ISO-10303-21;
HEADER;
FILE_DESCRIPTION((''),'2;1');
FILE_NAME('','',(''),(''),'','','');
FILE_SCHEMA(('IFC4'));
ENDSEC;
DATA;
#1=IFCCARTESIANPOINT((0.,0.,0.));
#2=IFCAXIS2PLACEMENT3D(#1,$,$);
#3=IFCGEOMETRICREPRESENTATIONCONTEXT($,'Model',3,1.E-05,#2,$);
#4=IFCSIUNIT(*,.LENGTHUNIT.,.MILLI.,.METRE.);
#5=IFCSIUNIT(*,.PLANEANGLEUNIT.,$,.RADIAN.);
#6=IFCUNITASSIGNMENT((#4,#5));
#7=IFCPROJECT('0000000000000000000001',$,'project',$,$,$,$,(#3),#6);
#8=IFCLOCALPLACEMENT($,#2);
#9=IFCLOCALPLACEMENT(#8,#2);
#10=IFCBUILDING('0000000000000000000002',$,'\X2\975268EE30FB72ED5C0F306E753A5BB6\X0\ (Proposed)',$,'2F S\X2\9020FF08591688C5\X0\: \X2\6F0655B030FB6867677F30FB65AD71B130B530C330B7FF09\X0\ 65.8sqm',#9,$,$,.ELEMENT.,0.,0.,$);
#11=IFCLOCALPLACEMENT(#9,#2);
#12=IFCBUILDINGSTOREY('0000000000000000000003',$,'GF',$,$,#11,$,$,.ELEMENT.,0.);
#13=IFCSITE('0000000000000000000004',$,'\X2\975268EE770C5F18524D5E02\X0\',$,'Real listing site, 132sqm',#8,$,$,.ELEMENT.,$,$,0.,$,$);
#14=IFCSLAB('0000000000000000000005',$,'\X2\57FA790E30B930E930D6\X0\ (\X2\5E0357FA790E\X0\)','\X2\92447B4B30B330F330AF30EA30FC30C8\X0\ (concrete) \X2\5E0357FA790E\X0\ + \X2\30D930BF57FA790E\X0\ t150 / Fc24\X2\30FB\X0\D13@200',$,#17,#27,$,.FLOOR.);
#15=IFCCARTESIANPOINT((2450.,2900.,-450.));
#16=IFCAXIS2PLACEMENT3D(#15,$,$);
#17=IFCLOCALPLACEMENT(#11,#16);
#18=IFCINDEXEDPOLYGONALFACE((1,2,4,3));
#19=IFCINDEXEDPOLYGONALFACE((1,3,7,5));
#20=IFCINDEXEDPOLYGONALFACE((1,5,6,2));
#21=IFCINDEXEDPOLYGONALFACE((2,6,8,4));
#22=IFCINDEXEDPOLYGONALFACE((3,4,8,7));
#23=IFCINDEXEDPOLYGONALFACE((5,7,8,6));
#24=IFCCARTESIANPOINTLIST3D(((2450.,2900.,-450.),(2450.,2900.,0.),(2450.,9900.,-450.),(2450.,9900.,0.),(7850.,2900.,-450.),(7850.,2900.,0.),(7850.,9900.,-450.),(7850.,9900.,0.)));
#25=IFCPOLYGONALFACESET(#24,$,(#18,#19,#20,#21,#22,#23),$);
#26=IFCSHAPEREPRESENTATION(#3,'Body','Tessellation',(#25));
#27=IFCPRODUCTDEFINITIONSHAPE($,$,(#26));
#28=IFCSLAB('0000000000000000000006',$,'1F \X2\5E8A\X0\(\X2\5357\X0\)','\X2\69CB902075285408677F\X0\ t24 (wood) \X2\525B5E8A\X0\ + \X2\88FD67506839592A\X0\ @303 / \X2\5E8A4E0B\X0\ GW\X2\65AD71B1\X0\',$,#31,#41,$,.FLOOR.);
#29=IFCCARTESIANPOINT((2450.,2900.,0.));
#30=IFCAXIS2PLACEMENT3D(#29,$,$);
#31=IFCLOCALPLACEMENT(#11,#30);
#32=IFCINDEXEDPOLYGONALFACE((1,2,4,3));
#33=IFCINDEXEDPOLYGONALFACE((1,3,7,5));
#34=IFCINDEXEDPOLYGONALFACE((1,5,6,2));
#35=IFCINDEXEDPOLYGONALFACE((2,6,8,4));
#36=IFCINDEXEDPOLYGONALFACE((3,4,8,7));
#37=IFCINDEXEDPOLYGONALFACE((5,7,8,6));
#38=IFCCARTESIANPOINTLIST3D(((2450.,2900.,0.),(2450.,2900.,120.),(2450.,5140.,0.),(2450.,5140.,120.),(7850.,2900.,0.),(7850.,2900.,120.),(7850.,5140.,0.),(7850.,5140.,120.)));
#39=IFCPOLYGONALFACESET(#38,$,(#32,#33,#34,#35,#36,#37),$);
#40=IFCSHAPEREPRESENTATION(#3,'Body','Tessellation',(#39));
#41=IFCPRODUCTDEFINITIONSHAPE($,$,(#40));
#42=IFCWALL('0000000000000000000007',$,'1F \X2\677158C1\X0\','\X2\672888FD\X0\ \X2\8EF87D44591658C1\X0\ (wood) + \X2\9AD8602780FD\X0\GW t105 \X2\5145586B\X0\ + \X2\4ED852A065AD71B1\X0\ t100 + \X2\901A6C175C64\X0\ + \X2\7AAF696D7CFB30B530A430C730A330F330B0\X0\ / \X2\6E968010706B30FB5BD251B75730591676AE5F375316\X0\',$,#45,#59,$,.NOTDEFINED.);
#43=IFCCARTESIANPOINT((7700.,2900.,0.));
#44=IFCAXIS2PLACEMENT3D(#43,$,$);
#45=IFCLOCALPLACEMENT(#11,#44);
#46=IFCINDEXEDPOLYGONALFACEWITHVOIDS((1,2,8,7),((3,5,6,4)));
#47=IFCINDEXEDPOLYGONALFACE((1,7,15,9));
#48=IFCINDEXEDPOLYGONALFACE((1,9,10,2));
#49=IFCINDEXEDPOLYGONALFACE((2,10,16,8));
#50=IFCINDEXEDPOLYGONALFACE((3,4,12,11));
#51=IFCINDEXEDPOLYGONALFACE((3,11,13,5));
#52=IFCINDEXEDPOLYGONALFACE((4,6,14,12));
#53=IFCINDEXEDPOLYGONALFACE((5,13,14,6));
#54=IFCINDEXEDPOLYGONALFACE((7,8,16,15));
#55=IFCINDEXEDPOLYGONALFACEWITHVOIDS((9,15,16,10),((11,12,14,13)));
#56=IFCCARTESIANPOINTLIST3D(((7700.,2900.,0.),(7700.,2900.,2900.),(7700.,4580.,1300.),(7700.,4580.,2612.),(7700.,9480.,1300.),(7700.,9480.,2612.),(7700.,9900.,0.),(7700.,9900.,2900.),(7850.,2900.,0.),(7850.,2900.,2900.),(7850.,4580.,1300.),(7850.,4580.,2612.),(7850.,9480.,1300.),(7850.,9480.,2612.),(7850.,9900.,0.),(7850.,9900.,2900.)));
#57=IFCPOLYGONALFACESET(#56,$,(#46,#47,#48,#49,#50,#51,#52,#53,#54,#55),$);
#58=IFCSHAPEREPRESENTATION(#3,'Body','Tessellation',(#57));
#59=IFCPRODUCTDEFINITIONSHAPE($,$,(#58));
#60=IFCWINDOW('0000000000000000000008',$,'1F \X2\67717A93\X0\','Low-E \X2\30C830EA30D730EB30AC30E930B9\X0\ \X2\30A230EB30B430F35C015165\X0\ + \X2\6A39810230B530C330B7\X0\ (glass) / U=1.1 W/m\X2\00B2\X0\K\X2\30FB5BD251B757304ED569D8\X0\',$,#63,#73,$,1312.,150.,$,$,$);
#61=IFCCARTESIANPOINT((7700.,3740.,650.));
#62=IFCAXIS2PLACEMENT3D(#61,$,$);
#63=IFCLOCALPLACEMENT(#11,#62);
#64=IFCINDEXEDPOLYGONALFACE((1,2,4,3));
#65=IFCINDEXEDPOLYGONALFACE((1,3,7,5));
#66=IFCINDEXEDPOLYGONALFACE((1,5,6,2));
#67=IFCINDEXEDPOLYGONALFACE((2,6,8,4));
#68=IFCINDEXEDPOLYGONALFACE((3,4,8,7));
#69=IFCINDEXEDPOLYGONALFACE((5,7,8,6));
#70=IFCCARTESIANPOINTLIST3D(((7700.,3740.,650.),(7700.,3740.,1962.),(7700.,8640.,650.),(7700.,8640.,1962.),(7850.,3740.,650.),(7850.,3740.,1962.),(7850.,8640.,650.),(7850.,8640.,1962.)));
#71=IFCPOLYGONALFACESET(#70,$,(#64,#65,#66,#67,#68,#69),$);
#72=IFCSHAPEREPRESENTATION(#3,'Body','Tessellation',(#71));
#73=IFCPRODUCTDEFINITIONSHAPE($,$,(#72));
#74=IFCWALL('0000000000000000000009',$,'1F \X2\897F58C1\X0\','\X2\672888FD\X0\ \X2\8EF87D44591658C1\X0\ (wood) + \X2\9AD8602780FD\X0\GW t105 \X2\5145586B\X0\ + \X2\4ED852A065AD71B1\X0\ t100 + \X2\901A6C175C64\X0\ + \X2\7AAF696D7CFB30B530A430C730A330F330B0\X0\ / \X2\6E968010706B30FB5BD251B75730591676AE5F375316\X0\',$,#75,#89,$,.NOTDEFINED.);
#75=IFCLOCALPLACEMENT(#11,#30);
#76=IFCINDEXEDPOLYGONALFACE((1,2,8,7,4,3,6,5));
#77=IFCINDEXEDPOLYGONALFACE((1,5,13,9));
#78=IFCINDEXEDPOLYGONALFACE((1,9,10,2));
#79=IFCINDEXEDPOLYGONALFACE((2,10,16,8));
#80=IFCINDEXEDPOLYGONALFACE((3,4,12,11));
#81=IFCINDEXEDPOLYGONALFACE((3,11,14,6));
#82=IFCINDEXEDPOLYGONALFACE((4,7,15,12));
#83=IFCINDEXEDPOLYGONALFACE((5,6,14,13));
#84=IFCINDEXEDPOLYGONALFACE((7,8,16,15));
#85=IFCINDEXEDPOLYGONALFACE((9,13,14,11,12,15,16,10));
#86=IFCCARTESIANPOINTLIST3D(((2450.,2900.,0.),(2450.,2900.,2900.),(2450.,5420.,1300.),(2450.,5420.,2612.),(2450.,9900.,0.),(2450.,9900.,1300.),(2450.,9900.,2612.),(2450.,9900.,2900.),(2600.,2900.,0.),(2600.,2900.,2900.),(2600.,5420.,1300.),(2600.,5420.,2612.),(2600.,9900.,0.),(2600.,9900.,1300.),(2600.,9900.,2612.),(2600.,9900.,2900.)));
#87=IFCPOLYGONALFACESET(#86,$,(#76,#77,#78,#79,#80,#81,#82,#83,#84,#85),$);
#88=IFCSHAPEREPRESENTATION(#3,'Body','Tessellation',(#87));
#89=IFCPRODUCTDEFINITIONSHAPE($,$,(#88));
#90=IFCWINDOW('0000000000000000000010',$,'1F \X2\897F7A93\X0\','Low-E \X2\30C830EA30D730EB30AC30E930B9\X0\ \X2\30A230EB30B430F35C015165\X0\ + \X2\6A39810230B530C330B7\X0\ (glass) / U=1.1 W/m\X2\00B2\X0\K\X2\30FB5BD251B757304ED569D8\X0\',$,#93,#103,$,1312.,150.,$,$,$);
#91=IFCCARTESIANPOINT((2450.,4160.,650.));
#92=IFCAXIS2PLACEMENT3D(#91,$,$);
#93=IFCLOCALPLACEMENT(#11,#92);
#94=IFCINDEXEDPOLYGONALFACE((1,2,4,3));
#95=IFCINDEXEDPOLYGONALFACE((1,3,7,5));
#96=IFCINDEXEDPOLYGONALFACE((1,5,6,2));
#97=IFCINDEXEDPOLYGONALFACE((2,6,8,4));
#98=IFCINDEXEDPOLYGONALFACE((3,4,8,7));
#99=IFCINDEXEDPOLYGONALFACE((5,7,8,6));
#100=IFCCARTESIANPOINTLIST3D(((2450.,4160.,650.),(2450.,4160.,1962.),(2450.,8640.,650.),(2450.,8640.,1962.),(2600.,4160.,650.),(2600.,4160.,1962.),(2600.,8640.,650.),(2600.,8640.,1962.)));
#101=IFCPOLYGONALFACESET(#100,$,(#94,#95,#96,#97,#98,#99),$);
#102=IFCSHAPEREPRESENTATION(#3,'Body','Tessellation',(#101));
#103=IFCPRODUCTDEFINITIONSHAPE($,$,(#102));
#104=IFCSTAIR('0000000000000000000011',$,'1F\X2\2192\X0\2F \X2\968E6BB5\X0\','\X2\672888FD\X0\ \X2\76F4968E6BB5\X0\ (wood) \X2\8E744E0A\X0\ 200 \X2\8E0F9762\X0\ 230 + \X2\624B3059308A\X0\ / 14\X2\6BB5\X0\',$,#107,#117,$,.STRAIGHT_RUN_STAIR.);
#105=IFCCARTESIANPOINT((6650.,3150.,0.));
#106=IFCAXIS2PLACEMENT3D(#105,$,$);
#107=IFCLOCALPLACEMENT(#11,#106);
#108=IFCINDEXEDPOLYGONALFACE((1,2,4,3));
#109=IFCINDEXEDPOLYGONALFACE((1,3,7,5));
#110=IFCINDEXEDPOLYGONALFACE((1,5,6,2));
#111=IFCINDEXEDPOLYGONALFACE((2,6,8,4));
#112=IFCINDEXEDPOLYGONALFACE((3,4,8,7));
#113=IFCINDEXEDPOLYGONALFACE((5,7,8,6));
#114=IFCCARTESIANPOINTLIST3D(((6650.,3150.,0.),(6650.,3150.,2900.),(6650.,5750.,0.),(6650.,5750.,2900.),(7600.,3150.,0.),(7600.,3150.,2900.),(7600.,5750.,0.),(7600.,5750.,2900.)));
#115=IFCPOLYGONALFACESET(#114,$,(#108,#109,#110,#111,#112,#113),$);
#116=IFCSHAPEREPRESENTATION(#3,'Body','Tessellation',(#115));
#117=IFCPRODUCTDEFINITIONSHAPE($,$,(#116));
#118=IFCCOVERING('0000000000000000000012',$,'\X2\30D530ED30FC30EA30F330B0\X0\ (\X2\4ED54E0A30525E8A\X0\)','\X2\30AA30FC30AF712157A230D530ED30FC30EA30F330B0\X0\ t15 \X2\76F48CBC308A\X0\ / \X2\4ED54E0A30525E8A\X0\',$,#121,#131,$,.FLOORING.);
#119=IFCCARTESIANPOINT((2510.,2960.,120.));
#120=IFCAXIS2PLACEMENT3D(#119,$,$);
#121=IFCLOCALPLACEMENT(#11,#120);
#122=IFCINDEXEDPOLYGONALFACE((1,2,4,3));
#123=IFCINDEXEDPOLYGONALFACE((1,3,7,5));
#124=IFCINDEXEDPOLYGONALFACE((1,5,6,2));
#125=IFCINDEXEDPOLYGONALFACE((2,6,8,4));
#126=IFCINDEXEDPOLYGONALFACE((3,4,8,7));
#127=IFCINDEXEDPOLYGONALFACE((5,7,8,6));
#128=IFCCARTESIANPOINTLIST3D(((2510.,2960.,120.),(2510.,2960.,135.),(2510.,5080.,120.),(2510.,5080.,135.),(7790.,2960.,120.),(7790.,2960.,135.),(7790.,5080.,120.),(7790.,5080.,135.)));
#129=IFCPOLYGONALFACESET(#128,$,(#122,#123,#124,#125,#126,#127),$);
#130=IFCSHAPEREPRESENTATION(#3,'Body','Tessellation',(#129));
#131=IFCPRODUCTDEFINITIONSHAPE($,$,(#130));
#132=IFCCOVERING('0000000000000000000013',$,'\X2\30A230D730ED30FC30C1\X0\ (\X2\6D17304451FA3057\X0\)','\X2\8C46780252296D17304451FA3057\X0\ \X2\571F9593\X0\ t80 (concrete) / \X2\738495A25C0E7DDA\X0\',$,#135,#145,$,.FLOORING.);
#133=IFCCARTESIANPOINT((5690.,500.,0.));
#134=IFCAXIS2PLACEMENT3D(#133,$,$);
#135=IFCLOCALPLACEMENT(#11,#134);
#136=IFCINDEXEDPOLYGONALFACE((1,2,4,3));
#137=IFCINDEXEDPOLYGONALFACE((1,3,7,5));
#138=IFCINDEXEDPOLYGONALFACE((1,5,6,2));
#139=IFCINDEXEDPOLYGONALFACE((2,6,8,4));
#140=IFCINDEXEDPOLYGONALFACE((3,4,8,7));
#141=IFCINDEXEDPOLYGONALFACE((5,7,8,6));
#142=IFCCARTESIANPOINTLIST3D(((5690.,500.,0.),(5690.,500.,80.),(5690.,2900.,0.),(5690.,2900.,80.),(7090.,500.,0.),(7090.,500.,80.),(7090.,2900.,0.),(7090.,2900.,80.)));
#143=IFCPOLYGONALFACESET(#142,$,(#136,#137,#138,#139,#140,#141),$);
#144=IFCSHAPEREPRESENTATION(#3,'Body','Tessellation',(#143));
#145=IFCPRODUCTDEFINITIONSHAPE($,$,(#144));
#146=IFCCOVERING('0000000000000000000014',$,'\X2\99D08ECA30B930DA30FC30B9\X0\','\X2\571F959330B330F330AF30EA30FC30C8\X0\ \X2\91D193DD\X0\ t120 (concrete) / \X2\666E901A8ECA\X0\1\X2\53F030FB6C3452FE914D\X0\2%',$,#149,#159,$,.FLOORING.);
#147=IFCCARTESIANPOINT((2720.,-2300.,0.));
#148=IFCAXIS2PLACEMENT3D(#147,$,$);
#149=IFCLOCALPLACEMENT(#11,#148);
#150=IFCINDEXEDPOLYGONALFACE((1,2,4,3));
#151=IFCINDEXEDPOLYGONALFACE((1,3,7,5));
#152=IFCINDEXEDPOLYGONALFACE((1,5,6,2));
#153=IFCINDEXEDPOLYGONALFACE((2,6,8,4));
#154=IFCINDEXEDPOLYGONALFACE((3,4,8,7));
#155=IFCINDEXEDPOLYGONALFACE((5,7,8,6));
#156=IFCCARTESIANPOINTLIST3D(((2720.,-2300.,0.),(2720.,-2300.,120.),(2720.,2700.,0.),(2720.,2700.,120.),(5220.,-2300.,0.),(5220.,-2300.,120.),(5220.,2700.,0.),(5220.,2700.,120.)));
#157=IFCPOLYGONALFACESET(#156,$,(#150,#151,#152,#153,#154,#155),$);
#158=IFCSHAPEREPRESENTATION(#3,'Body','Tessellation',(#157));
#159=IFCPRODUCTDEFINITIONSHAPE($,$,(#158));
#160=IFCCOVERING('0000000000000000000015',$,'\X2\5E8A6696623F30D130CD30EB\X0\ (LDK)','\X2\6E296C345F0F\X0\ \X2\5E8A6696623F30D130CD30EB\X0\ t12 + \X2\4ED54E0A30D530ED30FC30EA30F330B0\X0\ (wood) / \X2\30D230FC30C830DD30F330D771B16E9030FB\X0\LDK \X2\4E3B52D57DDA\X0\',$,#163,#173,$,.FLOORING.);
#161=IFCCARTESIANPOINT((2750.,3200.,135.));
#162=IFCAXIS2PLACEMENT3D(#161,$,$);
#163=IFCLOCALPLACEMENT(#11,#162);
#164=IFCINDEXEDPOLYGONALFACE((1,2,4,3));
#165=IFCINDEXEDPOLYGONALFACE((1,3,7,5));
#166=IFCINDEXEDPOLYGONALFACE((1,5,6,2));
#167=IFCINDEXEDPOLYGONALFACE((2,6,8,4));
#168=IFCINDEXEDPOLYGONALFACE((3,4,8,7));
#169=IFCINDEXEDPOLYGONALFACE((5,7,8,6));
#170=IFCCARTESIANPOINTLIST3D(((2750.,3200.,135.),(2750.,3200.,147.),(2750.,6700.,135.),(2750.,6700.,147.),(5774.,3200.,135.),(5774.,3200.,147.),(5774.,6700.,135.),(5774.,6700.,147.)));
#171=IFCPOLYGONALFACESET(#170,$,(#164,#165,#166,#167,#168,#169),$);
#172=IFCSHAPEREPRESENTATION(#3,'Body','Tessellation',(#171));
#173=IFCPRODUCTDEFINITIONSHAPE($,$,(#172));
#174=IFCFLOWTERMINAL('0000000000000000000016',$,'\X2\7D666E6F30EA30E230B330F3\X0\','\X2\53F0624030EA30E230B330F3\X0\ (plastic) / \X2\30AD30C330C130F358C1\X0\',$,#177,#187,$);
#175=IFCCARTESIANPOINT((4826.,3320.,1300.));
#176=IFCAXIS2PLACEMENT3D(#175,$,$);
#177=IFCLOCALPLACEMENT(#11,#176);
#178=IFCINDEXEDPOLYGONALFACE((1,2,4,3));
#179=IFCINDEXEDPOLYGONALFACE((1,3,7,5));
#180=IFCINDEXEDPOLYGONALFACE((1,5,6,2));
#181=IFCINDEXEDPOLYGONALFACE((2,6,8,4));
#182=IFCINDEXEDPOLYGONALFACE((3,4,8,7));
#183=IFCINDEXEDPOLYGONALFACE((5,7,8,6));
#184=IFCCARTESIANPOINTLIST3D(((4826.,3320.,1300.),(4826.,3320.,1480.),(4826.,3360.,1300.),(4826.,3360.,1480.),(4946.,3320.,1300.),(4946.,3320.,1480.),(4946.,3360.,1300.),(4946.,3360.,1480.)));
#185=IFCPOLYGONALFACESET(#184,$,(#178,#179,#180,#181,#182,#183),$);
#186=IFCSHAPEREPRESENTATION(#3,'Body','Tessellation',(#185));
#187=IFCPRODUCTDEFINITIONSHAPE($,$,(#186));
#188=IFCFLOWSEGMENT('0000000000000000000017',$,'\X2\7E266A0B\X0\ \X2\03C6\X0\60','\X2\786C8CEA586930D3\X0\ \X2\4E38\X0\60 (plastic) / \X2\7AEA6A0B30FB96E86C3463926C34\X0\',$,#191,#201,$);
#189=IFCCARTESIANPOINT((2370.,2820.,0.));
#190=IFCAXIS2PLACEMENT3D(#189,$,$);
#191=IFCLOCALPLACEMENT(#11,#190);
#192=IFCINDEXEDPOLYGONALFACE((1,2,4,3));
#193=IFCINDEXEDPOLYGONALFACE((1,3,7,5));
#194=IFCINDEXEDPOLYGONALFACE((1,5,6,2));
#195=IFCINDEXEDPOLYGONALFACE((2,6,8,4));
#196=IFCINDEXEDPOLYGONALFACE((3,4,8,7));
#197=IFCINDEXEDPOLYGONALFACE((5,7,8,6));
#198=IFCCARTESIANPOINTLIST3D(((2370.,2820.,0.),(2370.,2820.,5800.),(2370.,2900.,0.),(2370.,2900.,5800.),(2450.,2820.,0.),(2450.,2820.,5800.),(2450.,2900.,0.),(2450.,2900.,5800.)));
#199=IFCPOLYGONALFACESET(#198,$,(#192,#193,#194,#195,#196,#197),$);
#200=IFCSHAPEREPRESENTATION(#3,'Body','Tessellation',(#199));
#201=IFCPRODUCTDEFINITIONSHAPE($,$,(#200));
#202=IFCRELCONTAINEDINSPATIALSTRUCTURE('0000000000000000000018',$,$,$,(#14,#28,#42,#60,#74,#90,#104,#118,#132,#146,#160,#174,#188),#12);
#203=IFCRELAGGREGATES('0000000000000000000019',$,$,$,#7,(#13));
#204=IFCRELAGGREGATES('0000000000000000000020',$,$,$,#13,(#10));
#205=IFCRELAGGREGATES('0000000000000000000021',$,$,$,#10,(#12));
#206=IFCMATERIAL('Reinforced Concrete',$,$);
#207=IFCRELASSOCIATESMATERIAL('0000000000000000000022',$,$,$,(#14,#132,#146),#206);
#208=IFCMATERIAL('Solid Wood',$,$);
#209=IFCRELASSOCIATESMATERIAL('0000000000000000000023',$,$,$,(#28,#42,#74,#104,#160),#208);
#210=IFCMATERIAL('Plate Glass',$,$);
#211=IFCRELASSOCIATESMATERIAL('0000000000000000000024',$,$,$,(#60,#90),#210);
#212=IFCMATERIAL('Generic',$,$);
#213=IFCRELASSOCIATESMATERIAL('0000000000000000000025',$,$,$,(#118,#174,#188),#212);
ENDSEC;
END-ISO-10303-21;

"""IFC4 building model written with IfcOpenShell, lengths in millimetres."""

from ifc_helpers import new_model, si_unit, frame, frame_2d, origin, place, context, project, spatial, rectangle, extrude, material, element, fill, save


model = new_model("IFC4")

# Units and contexts
model_context = context("Model", 3, precision=1e-05, world=origin())
ifc_project = project(units=[si_unit("LENGTHUNIT", "METRE", prefix="MILLI"), si_unit("PLANEANGLEUNIT", "RADIAN")], contexts=[model_context])

# Site, building, storey
site_placement = place(None, origin())
site = spatial("IfcSite", under=ifc_project, at=site_placement, Name="青森県弘前市", ObjectType="Real listing site, 132sqm", CompositionType="ELEMENT", RefElevation=0.0)
building_placement = place(site_placement, origin())
building = spatial("IfcBuilding", under=site, at=building_placement, Name="青森・狭小の町家 (Proposed)", ObjectType="2F S造（外装: 漆喰・桧板・断熱サッシ） 65.8sqm", CompositionType="ELEMENT", ElevationOfRefHeight=0.0, ElevationOfTerrain=0.0)
storey_placement = place(building_placement, origin())
storey = spatial("IfcBuildingStorey", under=building, at=storey_placement, Name="GF", CompositionType="ELEMENT", Elevation=0.0)

# Shared definitions
ifc_material_1 = material(Name="Solid Wood")

# Slabs
ifc_material_2 = material(Name="Reinforced Concrete")
slab_1_placement = place(storey_placement, frame((2450.0, 2900.0, -450.0)))
element("IfcSlab", 1, at=slab_1_placement, inside=storey, material=ifc_material_2, Name="基礎スラブ (布基礎)", Description="鉄筋コンクリート (concrete) 布基礎 + ベタ基礎 t150 / Fc24・D13@200", PredefinedType="FLOOR", context=model_context, shape_type="SweptSolid", body=[
    extrude(rectangle(XDim=5400.0, YDim=7000.0, at=frame_2d((2700.0, 3500.0))), frame((2450.0, 2900.0, -450.0)), (0.0, 0.0, 1.0), 450.0),
])
slab_2_placement = place(storey_placement, frame((2450.0, 2900.0, 0.0)))
element("IfcSlab", 2, at=slab_2_placement, inside=storey, material=ifc_material_1, Name="1F 床(南)", Description="構造用合板 t24 (wood) 剛床 + 製材根太 @303 / 床下 GW断熱", PredefinedType="FLOOR", context=model_context, shape_type="SweptSolid", body=[
    extrude(rectangle(XDim=5400.0, YDim=2240.0, at=frame_2d((2700.0, 1120.0))), frame((2450.0, 2900.0, 0.0)), (0.0, 0.0, 1.0), 120.0),
])

# Shared definitions
ifc_material_3 = material(Name="Plate Glass")

# Walls, openings, windows
wall_1_placement = place(storey_placement, frame((7700.0, 2900.0, 0.0)))
wall_1 = element("IfcWall", 3, at=wall_1_placement, inside=storey, material=ifc_material_1, Name="1F 東壁", Description="木製 軸組外壁 (wood) + 高性能GW t105 充填 + 付加断熱 t100 + 通気層 + 窯業系サイディング / 準耐火・寒冷地外皮強化", PredefinedType="NOTDEFINED", context=model_context, shape_type="SweptSolid", body=[
    extrude(rectangle(XDim=150.0, YDim=7000.0, at=frame_2d((75.0, 3500.0))), frame((7700.0, 2900.0, 0.0)), (0.0, 0.0, 1.0), 2900.0),
])
opening_1_placement = place(storey_placement, frame((7700.0, 3740.0, 650.0)))
opening_1 = element("IfcOpeningElement", 4, at=opening_1_placement, cuts=wall_1, PredefinedType="NOTDEFINED", context=model_context, shape_type="SweptSolid", body=[
    extrude(rectangle(XDim=150.0, YDim=4900.0, at=frame_2d((75.0, 2450.0))), frame((7700.0, 3740.0, 650.0)), (0.0, 0.0, 1.0), 1312.0),
])
window_1_placement = place(storey_placement, frame((7700.0, 3740.0, 650.0)))
window_1 = element("IfcWindow", 5, at=window_1_placement, inside=storey, material=ifc_material_3, Name="1F 東窓", Description="Low-E トリプルガラス アルゴン封入 + 樹脂サッシ (glass) / U=1.1 W/m²K・寒冷地仕様", OverallHeight=1312.0, OverallWidth=150.0, context=model_context, shape_type="SweptSolid", body=[
    extrude(rectangle(XDim=150.0, YDim=4900.0, at=frame_2d((75.0, 2450.0))), frame((7700.0, 3740.0, 650.0)), (0.0, 0.0, 1.0), 1312.0),
])
fill(opening_1, window_1)
wall_2_placement = place(storey_placement, frame((2450.0, 2900.0, 0.0)))
wall_2 = element("IfcWall", 6, at=wall_2_placement, inside=storey, material=ifc_material_1, Name="1F 西壁", Description="木製 軸組外壁 (wood) + 高性能GW t105 充填 + 付加断熱 t100 + 通気層 + 窯業系サイディング / 準耐火・寒冷地外皮強化", PredefinedType="NOTDEFINED", context=model_context, shape_type="SweptSolid", body=[
    extrude(rectangle(XDim=150.0, YDim=7000.0, at=frame_2d((75.0, 3500.0))), frame((2450.0, 2900.0, 0.0)), (0.0, 0.0, 1.0), 2900.0),
])
opening_2_placement = place(storey_placement, frame((2450.0, 4160.0, 650.0)))
opening_2 = element("IfcOpeningElement", 7, at=opening_2_placement, cuts=wall_2, PredefinedType="NOTDEFINED", context=model_context, shape_type="SweptSolid", body=[
    extrude(rectangle(XDim=150.0, YDim=4480.0, at=frame_2d((75.0, 2240.0))), frame((2450.0, 4160.0, 650.0)), (0.0, 0.0, 1.0), 1312.0),
])
window_2_placement = place(storey_placement, frame((2450.0, 4160.0, 650.0)))
window_2 = element("IfcWindow", 8, at=window_2_placement, inside=storey, material=ifc_material_3, Name="1F 西窓", Description="Low-E トリプルガラス アルゴン封入 + 樹脂サッシ (glass) / U=1.1 W/m²K・寒冷地仕様", OverallHeight=1312.0, OverallWidth=150.0, context=model_context, shape_type="SweptSolid", body=[
    extrude(rectangle(XDim=150.0, YDim=4480.0, at=frame_2d((75.0, 2240.0))), frame((2450.0, 4160.0, 650.0)), (0.0, 0.0, 1.0), 1312.0),
])
fill(opening_2, window_2)

# Stair
stair_placement = place(storey_placement, frame((6650.0, 3150.0, 0.0)))
element("IfcStair", 9, at=stair_placement, inside=storey, material=ifc_material_1, Name="1F→2F 階段", Description="木製 直階段 (wood) 蹴上 200 踏面 230 + 手すり / 14段", PredefinedType="STRAIGHT_RUN_STAIR", context=model_context, shape_type="SweptSolid", body=[
    extrude(rectangle(XDim=950.0, YDim=2600.0, at=frame_2d((475.0, 1300.0))), frame((6650.0, 3150.0, 0.0)), (0.0, 0.0, 1.0), 2900.0),
])

# Coverings
ifc_material_4 = material(Name="Generic")
covering_1_placement = place(storey_placement, frame((2510.0, 2960.0, 120.0)))
element("IfcCovering", 10, at=covering_1_placement, inside=storey, material=ifc_material_4, Name="フローリング (仕上げ床)", Description="オーク無垢フローリング t15 直貼り / 仕上げ床", PredefinedType="FLOORING", context=model_context, shape_type="SweptSolid", body=[
    extrude(rectangle(XDim=5280.0, YDim=2120.0, at=frame_2d((2640.0, 1060.0))), frame((2510.0, 2960.0, 120.0)), (0.0, 0.0, 1.0), 15.0),
])
covering_2_placement = place(storey_placement, frame((5690.0, 500.0, 0.0)))
element("IfcCovering", 11, at=covering_2_placement, inside=storey, material=ifc_material_2, Name="アプローチ (洗い出し)", Description="豆砂利洗い出し 土間 t80 (concrete) / 玄関導線", PredefinedType="FLOORING", context=model_context, shape_type="SweptSolid", body=[
    extrude(rectangle(XDim=1400.0, YDim=2400.0, at=frame_2d((700.0, 1200.0))), frame((5690.0, 500.0, 0.0)), (0.0, 0.0, 1.0), 80.0),
])
covering_3_placement = place(storey_placement, frame((2720.0, -2300.0, 0.0)))
element("IfcCovering", 12, at=covering_3_placement, inside=storey, material=ifc_material_2, Name="駐車スペース", Description="土間コンクリート 金鏝 t120 (concrete) / 普通車1台・水勾配2%", PredefinedType="FLOORING", context=model_context, shape_type="SweptSolid", body=[
    extrude(rectangle(XDim=2500.0, YDim=5000.0, at=frame_2d((1250.0, 2500.0))), frame((2720.0, -2300.0, 0.0)), (0.0, 0.0, 1.0), 120.0),
])
covering_4_placement = place(storey_placement, frame((2750.0, 3200.0, 135.0)))
element("IfcCovering", 13, at=covering_4_placement, inside=storey, material=ifc_material_1, Name="床暖房パネル (LDK)", Description="温水式 床暖房パネル t12 + 仕上フローリング (wood) / ヒートポンプ熱源・LDK 主動線", PredefinedType="FLOORING", context=model_context, shape_type="SweptSolid", body=[
    extrude(rectangle(XDim=3024.0, YDim=3500.0, at=frame_2d((1512.0, 1750.0))), frame((2750.0, 3200.0, 135.0)), (0.0, 0.0, 1.0), 12.0),
])

# Flow terminal
flow_terminal_placement = place(storey_placement, frame((4826.0, 3320.0, 1300.0)))
element("IfcFlowTerminal", 14, at=flow_terminal_placement, inside=storey, material=ifc_material_4, Name="給湯リモコン", Description="台所リモコン (plastic) / キッチン壁", context=model_context, shape_type="SweptSolid", body=[
    extrude(rectangle(XDim=120.0, YDim=40.0, at=frame_2d((60.0, 20.0))), frame((4826.0, 3320.0, 1300.0)), (0.0, 0.0, 1.0), 180.0),
])

# Flow segment
flow_segment_1_placement = place(storey_placement, frame((2370.0, 2820.0, 0.0)))
element("IfcFlowSegment", 15, at=flow_segment_1_placement, inside=storey, material=ifc_material_4, Name="縦樋 φ60", Description="硬質塩ビ 丸60 (plastic) / 竪樋・雨水排水", context=model_context, shape_type="SweptSolid", body=[
    extrude(rectangle(XDim=80.0, YDim=80.0, at=frame_2d((40.0, 40.0))), frame((2370.0, 2820.0, 0.0)), (0.0, 0.0, 1.0), 5800.0),
])

save(model, "model.ifc")
